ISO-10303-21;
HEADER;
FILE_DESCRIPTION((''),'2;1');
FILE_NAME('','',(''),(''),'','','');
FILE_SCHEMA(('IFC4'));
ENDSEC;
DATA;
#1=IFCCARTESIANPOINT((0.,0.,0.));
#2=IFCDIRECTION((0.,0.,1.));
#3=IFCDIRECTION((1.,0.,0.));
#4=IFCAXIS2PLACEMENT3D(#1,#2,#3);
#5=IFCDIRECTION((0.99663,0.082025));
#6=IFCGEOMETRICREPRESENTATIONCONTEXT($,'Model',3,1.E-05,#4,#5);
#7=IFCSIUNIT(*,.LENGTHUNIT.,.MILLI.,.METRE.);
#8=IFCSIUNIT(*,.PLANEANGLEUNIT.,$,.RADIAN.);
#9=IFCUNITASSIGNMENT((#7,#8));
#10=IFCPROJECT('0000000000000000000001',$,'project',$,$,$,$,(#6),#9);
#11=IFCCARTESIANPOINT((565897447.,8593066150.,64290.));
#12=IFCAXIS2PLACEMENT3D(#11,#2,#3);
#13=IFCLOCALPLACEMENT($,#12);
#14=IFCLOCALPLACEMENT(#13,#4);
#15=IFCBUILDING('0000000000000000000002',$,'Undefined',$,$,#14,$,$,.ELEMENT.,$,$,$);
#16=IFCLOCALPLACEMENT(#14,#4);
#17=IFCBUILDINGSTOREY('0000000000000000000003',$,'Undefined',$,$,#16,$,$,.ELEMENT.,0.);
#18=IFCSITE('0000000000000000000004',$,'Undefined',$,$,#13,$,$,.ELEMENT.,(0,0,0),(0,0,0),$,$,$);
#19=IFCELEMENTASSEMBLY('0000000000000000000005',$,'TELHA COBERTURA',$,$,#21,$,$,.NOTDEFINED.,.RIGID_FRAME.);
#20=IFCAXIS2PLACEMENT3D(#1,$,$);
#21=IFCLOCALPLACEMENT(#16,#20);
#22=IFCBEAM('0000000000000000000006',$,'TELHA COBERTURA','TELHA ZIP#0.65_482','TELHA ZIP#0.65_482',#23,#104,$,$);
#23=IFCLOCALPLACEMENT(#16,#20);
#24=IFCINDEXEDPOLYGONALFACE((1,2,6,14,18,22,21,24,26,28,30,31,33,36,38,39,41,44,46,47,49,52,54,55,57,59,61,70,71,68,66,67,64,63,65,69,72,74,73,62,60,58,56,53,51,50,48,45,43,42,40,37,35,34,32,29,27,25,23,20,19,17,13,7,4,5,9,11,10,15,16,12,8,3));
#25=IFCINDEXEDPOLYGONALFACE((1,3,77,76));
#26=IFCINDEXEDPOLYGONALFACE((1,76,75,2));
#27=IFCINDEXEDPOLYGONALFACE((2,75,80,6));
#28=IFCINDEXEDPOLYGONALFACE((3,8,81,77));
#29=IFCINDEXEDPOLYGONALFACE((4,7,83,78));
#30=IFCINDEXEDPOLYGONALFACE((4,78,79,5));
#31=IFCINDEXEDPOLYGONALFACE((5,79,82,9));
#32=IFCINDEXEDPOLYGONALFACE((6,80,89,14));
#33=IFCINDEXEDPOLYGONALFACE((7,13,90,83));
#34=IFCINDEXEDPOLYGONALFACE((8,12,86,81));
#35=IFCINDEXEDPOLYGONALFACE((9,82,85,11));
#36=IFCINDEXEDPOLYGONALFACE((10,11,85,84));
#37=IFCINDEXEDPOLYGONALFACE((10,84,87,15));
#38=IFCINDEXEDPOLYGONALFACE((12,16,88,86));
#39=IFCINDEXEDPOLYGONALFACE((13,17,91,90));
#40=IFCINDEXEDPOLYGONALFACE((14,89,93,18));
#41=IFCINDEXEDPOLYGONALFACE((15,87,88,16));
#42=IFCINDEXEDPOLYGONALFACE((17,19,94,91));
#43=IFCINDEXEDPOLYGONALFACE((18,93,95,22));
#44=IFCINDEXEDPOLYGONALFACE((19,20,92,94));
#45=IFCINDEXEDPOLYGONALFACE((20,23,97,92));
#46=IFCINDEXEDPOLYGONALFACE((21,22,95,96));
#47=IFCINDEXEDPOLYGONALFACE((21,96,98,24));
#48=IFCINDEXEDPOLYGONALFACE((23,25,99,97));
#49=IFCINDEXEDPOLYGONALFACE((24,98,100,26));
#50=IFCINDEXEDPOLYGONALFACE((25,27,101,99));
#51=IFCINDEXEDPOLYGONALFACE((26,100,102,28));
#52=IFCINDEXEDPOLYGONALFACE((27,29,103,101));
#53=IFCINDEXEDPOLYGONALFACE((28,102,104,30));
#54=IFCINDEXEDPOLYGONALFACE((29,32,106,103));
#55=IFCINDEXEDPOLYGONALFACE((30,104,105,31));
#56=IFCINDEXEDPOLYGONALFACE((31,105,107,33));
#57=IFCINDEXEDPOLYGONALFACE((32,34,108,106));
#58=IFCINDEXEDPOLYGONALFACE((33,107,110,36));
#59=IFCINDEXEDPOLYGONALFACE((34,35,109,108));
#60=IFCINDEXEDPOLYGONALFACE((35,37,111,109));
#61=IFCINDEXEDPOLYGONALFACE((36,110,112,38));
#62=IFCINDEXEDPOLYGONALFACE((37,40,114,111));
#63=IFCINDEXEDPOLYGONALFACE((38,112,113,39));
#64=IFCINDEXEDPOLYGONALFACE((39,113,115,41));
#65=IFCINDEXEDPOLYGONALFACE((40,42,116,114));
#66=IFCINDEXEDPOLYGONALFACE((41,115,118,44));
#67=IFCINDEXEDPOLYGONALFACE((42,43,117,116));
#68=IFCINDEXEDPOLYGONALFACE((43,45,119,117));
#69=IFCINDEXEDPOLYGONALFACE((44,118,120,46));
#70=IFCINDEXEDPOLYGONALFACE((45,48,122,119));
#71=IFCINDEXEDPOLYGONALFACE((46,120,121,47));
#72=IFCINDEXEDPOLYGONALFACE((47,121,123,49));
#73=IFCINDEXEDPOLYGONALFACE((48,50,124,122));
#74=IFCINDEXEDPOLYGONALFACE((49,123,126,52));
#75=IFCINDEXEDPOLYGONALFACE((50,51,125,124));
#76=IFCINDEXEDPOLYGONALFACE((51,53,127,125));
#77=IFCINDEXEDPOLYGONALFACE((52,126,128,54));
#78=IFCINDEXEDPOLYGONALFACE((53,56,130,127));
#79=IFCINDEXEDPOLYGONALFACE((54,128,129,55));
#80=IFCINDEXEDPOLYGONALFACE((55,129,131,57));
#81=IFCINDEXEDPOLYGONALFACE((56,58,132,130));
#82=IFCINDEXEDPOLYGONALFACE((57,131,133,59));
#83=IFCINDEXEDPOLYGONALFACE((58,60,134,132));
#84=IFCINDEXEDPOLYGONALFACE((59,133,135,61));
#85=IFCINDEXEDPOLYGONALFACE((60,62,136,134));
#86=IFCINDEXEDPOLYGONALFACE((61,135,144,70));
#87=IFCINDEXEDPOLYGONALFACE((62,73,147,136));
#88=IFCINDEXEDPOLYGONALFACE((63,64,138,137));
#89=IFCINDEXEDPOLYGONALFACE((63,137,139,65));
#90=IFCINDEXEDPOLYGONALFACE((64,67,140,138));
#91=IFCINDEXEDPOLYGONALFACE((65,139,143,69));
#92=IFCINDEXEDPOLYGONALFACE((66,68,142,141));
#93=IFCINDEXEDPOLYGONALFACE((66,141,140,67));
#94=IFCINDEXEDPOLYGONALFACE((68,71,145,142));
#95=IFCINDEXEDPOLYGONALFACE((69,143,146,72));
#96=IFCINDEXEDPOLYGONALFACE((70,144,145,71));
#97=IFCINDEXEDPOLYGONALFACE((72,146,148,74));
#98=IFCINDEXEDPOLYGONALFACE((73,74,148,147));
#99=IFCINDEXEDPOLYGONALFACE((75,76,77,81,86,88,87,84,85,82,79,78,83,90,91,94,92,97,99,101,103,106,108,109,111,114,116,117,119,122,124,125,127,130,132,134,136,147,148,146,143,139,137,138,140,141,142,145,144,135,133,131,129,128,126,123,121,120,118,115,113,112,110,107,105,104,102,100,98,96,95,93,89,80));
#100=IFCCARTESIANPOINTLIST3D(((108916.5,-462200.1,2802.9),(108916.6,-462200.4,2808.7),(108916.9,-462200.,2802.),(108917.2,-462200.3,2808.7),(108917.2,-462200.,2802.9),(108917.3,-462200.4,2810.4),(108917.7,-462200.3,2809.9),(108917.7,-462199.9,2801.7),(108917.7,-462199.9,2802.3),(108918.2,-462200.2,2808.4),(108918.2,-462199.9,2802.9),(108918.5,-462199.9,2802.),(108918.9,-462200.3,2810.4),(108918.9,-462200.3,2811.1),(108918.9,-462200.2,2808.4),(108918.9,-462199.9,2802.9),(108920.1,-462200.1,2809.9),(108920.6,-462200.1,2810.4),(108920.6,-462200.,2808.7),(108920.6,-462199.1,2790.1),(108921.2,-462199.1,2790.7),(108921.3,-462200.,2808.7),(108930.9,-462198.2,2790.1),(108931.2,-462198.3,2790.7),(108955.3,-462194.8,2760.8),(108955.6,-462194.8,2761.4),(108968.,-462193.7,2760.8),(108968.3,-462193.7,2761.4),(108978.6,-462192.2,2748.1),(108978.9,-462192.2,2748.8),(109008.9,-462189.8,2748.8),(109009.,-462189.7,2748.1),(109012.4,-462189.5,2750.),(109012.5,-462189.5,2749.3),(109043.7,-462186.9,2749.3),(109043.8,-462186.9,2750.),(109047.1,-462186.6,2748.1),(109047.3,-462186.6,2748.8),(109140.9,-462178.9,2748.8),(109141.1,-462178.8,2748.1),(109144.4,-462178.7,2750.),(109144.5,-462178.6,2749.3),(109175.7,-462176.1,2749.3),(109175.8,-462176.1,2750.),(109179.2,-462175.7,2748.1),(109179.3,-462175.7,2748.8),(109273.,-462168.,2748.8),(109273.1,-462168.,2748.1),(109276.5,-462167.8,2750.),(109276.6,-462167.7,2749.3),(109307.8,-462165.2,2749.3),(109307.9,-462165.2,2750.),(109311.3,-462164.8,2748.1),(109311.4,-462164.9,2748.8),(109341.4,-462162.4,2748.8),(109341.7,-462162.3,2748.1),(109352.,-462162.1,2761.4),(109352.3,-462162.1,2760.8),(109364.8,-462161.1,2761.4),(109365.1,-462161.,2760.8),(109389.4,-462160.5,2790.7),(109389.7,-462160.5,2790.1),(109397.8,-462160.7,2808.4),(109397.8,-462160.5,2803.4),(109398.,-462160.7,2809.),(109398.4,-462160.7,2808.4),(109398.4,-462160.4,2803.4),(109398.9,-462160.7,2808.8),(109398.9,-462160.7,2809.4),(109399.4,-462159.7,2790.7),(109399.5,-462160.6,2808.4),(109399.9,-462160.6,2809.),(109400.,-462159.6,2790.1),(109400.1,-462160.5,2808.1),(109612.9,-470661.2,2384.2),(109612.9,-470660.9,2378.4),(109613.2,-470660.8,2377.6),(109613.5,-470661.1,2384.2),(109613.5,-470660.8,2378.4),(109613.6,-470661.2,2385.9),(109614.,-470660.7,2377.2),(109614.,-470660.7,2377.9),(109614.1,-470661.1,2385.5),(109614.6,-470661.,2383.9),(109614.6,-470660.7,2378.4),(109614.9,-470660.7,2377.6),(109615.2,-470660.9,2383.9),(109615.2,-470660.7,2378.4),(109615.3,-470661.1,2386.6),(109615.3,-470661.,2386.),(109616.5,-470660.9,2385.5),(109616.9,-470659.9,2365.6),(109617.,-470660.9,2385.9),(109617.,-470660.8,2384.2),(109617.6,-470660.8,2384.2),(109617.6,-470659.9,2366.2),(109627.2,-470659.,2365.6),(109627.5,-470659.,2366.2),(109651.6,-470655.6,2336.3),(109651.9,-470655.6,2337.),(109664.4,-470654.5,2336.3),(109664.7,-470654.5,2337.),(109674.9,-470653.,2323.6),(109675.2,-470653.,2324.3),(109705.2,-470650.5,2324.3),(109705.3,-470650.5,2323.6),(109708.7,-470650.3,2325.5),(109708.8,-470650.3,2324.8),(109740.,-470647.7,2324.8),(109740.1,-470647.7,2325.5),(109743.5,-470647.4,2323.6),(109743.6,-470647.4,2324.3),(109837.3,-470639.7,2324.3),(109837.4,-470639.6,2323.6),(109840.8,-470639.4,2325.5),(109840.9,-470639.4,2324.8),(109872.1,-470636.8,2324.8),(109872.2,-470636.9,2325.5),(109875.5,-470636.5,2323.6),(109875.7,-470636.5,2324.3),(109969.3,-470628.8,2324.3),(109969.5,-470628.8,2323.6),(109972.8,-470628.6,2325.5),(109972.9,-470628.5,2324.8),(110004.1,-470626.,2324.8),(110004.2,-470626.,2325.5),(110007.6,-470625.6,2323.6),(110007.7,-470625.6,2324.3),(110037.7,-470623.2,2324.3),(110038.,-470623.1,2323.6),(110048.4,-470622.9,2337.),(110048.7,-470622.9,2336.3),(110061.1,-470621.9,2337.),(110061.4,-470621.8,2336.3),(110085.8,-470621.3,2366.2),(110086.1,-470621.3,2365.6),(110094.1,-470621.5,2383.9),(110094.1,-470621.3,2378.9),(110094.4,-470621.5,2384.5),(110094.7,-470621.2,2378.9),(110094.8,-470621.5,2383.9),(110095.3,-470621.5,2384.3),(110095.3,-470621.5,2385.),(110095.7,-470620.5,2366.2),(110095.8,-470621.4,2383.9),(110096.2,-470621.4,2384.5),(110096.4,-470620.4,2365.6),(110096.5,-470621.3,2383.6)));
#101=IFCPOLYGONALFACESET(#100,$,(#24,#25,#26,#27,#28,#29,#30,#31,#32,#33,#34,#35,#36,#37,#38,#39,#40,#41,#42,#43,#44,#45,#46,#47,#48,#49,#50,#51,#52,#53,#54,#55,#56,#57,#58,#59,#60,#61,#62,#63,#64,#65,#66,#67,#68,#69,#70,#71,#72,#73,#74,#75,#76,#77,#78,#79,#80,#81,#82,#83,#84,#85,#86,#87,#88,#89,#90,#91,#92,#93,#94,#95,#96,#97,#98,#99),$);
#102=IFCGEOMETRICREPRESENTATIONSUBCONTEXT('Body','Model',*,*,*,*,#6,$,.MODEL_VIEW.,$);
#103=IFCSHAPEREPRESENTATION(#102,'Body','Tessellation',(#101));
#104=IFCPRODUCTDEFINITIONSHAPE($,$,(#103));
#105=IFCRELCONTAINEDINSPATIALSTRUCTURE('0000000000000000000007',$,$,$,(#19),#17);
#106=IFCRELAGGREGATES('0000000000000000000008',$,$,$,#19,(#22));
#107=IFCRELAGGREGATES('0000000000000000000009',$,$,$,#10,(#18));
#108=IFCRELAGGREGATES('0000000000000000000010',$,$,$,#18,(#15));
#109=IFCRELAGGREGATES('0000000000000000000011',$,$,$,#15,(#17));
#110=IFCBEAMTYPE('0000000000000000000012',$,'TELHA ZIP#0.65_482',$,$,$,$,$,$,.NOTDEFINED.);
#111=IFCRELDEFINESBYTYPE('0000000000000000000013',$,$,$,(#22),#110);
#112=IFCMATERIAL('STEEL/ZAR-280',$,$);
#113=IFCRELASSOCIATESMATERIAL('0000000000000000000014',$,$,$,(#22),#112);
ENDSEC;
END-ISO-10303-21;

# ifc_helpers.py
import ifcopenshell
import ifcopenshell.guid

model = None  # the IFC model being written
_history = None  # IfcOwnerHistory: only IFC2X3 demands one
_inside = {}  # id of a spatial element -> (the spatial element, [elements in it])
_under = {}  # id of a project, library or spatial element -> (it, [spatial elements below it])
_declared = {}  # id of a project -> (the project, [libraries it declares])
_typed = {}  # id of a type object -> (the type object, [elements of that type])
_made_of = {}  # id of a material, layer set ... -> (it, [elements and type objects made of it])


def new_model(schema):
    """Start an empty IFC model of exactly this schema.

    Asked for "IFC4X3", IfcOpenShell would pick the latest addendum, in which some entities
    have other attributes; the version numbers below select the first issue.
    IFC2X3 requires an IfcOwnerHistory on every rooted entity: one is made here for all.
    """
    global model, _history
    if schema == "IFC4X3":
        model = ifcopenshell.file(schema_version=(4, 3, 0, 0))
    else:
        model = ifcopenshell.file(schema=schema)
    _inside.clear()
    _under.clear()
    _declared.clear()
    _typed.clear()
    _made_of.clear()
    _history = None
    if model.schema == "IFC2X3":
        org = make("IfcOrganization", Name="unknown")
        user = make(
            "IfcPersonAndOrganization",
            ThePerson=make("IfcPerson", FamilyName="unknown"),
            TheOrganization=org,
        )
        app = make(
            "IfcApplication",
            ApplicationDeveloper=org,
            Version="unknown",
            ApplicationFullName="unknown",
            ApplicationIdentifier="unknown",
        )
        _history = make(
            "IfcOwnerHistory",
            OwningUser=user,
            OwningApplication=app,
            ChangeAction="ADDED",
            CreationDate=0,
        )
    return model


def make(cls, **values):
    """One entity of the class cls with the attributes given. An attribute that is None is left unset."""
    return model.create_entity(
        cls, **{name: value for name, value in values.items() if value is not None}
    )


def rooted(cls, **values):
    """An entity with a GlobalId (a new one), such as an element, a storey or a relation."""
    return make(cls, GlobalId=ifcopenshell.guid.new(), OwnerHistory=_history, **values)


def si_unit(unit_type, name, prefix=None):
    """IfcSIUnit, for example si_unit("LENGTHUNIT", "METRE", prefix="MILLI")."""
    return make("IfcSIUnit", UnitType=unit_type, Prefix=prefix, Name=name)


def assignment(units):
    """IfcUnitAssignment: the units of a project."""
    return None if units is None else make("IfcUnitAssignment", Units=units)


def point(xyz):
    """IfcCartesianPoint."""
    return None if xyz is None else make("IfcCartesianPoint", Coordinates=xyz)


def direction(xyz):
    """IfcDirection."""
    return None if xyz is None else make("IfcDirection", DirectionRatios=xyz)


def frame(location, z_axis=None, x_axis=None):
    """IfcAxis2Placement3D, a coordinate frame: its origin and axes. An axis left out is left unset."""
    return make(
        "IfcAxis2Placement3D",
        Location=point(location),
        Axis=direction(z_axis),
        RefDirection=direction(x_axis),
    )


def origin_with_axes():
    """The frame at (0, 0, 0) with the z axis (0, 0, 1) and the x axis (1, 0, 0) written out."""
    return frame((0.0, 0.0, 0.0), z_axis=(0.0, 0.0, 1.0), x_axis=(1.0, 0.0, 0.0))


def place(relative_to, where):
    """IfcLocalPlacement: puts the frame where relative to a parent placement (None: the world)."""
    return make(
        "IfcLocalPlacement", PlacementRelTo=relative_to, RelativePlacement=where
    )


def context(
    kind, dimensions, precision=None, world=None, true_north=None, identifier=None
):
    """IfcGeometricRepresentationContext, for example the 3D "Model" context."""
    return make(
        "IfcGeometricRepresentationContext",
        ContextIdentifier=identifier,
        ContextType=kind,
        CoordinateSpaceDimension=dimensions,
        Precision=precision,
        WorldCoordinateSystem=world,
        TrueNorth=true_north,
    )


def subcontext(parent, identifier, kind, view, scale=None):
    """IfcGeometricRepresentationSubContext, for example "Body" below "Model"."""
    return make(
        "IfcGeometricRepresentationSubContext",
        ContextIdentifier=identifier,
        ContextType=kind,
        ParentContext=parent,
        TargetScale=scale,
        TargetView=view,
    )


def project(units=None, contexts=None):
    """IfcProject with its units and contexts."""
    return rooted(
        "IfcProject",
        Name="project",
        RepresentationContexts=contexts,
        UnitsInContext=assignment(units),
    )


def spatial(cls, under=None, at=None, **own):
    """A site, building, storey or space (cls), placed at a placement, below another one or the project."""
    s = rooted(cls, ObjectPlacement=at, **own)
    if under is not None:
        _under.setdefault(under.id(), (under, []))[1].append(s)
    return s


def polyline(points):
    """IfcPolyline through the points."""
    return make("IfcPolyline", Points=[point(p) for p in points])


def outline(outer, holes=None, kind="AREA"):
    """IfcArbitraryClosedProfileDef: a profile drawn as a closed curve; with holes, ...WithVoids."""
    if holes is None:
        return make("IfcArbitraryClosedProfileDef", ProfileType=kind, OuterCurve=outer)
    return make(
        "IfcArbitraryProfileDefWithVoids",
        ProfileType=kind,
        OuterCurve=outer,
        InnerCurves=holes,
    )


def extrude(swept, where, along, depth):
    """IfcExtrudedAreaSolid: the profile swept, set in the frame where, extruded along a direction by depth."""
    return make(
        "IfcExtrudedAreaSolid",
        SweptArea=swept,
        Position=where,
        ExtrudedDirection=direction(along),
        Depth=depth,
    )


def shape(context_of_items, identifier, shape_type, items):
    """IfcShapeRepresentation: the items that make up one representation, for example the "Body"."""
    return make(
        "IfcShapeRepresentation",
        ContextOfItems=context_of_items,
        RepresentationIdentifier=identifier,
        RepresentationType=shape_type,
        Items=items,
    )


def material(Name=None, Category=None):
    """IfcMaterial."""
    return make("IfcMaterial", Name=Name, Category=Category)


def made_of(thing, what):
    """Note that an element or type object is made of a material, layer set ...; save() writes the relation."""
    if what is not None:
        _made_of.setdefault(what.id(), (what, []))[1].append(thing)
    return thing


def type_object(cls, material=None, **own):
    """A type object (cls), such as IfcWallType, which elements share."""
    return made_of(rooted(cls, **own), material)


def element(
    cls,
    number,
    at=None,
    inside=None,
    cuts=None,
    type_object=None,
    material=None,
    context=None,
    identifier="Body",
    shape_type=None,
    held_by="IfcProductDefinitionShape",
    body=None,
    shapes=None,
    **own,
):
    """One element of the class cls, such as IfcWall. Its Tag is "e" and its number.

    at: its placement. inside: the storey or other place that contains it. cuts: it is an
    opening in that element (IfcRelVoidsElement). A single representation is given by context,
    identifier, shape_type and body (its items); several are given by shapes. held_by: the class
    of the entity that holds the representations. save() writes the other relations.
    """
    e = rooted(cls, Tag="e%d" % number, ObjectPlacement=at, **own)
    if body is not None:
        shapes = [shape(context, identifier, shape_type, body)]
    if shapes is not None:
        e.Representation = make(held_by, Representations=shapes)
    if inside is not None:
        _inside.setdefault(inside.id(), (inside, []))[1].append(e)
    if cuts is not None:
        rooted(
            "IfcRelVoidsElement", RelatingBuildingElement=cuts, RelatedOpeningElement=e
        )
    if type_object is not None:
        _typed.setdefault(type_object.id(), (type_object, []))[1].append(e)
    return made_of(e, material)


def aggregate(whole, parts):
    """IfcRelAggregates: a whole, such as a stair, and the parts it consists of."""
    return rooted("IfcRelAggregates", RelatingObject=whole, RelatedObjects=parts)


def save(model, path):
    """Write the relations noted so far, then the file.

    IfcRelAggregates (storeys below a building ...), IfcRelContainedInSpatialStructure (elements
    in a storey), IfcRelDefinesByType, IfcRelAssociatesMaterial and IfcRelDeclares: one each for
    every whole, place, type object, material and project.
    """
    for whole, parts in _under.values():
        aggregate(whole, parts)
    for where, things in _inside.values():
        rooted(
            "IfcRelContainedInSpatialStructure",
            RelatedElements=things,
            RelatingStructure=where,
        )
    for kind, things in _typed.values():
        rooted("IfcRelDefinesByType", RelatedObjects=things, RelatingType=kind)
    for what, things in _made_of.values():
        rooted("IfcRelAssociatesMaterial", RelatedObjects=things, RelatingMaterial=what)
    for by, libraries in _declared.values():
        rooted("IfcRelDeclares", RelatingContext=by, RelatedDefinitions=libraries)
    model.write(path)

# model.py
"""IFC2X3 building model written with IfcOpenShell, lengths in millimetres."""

from ifc_helpers import new_model, si_unit, direction, frame, origin_with_axes, place, context, subcontext, project, spatial, polyline, outline, extrude, material, type_object, element, aggregate, save


model = new_model("IFC2X3")

# Units and contexts
model_context = context("Model", 3, precision=1e-05, world=origin_with_axes(), true_north=direction((0.99663, 0.082025)))
body_context = subcontext(model_context, "Body", "Model", "MODEL_VIEW")
ifc_project = project(units=[si_unit("LENGTHUNIT", "METRE", prefix="MILLI"), si_unit("PLANEANGLEUNIT", "RADIAN")], contexts=[model_context])

# Site, building, storey
site_placement = place(None, frame((565897447.0, 8593066150.0, 64290.0), z_axis=(0.0, 0.0, 1.0), x_axis=(1.0, 0.0, 0.0)))
site = spatial("IfcSite", under=ifc_project, at=site_placement, Name="Undefined", CompositionType="ELEMENT", RefLatitude=(0, 0, 0), RefLongitude=(0, 0, 0))
building_placement = place(site_placement, origin_with_axes())
building = spatial("IfcBuilding", under=site, at=building_placement, Name="Undefined", CompositionType="ELEMENT")
storey_placement = place(building_placement, origin_with_axes())
storey = spatial("IfcBuildingStorey", under=building, at=storey_placement, Name="Undefined", CompositionType="ELEMENT", Elevation=0.0)

# Element assembly, beam
ifc_material_1 = material(Name="STEEL/ZAR-280")
beam_type_1 = type_object("IfcBeamType", Name="TELHA ZIP#0.65_482", PredefinedType="NOTDEFINED")
assembly_1_placement = place(storey_placement, origin_with_axes())
assembly_1 = element("IfcElementAssembly", 1, at=assembly_1_placement, inside=storey, Name="TELHA COBERTURA", AssemblyPlace="NOTDEFINED", PredefinedType="RIGID_FRAME")
beam_1_placement = place(assembly_1_placement, frame((109854.6, -470639.8, 2354.8), z_axis=(0.004096, -0.049769, 0.998752), x_axis=(-0.081923, 0.995387, 0.049938)))
beam_1 = element("IfcBeam", 2, at=beam_1_placement, type_object=beam_type_1, material=ifc_material_1, Name="TELHA COBERTURA", Description="TELHA ZIP#0.65_482", ObjectType="TELHA ZIP#0.65_482", context=body_context, shape_type="SweptSolid", body=[
    extrude(outline(polyline([(240.5, 29.7), (241.4, 30.2), (242.4, 29.7), (242.6, 28.9), (242.6, 10.8), (232.2, 10.8), (207.6, -18.5), (194.9, -18.5), (184.2, -31.2), (153.7, -31.2), (150.2, -30.0), (118.9, -30.0), (115.4, -31.2), (21.2, -31.2), (17.7, -30.0), (-13.6, -30.0), (-17.1, -31.2), (-111.3, -31.2), (-114.8, -30.0), (-146.1, -30.0), (-149.6, -31.2), (-180.1, -31.2), (-190.8, -18.5), (-203.6, -18.5), (-228.1, 10.8), (-238.5, 10.8), (-238.5, 29.5), (-239.0, 30.7), (-240.2, 31.2), (-241.4, 30.7), (-241.9, 29.5), (-241.9, 23.6), (-241.4, 23.1), (-240.9, 23.6), (-240.9, 29.1), (-240.2, 29.1), (-240.2, 23.6), (-240.6, 22.8), (-241.4, 22.4), (-242.3, 22.8), (-242.6, 23.6), (-242.6, 29.5), (-241.9, 31.2), (-240.2, 31.9), (-238.5, 31.2), (-237.9, 29.5), (-237.9, 11.4), (-227.8, 11.4), (-203.2, -17.9), (-190.4, -17.9), (-179.8, -30.5), (-149.7, -30.5), (-146.2, -29.4), (-114.7, -29.4), (-111.2, -30.5), (-17.2, -30.5), (-13.7, -29.4), (17.8, -29.4), (21.3, -30.5), (115.3, -30.5), (118.8, -29.4), (150.3, -29.4), (153.8, -30.5), (183.9, -30.5), (194.6, -17.9), (207.4, -17.9), (231.9, 11.4), (241.9, 11.4), (241.9, 29.1), (241.4, 29.5), (240.9, 29.1), (240.9, 24.1), (240.2, 24.1), (240.2, 29.2), (240.5, 29.7)])), frame((8500.0, 0.0, 0.0), z_axis=(-1.0, 0.0, 0.0), x_axis=(0.0, -1.0, 0.0)), (0.0, 0.0, 1.0), 8500.0),
])
aggregate(assembly_1, [beam_1])

save(model, "model.ifc")
